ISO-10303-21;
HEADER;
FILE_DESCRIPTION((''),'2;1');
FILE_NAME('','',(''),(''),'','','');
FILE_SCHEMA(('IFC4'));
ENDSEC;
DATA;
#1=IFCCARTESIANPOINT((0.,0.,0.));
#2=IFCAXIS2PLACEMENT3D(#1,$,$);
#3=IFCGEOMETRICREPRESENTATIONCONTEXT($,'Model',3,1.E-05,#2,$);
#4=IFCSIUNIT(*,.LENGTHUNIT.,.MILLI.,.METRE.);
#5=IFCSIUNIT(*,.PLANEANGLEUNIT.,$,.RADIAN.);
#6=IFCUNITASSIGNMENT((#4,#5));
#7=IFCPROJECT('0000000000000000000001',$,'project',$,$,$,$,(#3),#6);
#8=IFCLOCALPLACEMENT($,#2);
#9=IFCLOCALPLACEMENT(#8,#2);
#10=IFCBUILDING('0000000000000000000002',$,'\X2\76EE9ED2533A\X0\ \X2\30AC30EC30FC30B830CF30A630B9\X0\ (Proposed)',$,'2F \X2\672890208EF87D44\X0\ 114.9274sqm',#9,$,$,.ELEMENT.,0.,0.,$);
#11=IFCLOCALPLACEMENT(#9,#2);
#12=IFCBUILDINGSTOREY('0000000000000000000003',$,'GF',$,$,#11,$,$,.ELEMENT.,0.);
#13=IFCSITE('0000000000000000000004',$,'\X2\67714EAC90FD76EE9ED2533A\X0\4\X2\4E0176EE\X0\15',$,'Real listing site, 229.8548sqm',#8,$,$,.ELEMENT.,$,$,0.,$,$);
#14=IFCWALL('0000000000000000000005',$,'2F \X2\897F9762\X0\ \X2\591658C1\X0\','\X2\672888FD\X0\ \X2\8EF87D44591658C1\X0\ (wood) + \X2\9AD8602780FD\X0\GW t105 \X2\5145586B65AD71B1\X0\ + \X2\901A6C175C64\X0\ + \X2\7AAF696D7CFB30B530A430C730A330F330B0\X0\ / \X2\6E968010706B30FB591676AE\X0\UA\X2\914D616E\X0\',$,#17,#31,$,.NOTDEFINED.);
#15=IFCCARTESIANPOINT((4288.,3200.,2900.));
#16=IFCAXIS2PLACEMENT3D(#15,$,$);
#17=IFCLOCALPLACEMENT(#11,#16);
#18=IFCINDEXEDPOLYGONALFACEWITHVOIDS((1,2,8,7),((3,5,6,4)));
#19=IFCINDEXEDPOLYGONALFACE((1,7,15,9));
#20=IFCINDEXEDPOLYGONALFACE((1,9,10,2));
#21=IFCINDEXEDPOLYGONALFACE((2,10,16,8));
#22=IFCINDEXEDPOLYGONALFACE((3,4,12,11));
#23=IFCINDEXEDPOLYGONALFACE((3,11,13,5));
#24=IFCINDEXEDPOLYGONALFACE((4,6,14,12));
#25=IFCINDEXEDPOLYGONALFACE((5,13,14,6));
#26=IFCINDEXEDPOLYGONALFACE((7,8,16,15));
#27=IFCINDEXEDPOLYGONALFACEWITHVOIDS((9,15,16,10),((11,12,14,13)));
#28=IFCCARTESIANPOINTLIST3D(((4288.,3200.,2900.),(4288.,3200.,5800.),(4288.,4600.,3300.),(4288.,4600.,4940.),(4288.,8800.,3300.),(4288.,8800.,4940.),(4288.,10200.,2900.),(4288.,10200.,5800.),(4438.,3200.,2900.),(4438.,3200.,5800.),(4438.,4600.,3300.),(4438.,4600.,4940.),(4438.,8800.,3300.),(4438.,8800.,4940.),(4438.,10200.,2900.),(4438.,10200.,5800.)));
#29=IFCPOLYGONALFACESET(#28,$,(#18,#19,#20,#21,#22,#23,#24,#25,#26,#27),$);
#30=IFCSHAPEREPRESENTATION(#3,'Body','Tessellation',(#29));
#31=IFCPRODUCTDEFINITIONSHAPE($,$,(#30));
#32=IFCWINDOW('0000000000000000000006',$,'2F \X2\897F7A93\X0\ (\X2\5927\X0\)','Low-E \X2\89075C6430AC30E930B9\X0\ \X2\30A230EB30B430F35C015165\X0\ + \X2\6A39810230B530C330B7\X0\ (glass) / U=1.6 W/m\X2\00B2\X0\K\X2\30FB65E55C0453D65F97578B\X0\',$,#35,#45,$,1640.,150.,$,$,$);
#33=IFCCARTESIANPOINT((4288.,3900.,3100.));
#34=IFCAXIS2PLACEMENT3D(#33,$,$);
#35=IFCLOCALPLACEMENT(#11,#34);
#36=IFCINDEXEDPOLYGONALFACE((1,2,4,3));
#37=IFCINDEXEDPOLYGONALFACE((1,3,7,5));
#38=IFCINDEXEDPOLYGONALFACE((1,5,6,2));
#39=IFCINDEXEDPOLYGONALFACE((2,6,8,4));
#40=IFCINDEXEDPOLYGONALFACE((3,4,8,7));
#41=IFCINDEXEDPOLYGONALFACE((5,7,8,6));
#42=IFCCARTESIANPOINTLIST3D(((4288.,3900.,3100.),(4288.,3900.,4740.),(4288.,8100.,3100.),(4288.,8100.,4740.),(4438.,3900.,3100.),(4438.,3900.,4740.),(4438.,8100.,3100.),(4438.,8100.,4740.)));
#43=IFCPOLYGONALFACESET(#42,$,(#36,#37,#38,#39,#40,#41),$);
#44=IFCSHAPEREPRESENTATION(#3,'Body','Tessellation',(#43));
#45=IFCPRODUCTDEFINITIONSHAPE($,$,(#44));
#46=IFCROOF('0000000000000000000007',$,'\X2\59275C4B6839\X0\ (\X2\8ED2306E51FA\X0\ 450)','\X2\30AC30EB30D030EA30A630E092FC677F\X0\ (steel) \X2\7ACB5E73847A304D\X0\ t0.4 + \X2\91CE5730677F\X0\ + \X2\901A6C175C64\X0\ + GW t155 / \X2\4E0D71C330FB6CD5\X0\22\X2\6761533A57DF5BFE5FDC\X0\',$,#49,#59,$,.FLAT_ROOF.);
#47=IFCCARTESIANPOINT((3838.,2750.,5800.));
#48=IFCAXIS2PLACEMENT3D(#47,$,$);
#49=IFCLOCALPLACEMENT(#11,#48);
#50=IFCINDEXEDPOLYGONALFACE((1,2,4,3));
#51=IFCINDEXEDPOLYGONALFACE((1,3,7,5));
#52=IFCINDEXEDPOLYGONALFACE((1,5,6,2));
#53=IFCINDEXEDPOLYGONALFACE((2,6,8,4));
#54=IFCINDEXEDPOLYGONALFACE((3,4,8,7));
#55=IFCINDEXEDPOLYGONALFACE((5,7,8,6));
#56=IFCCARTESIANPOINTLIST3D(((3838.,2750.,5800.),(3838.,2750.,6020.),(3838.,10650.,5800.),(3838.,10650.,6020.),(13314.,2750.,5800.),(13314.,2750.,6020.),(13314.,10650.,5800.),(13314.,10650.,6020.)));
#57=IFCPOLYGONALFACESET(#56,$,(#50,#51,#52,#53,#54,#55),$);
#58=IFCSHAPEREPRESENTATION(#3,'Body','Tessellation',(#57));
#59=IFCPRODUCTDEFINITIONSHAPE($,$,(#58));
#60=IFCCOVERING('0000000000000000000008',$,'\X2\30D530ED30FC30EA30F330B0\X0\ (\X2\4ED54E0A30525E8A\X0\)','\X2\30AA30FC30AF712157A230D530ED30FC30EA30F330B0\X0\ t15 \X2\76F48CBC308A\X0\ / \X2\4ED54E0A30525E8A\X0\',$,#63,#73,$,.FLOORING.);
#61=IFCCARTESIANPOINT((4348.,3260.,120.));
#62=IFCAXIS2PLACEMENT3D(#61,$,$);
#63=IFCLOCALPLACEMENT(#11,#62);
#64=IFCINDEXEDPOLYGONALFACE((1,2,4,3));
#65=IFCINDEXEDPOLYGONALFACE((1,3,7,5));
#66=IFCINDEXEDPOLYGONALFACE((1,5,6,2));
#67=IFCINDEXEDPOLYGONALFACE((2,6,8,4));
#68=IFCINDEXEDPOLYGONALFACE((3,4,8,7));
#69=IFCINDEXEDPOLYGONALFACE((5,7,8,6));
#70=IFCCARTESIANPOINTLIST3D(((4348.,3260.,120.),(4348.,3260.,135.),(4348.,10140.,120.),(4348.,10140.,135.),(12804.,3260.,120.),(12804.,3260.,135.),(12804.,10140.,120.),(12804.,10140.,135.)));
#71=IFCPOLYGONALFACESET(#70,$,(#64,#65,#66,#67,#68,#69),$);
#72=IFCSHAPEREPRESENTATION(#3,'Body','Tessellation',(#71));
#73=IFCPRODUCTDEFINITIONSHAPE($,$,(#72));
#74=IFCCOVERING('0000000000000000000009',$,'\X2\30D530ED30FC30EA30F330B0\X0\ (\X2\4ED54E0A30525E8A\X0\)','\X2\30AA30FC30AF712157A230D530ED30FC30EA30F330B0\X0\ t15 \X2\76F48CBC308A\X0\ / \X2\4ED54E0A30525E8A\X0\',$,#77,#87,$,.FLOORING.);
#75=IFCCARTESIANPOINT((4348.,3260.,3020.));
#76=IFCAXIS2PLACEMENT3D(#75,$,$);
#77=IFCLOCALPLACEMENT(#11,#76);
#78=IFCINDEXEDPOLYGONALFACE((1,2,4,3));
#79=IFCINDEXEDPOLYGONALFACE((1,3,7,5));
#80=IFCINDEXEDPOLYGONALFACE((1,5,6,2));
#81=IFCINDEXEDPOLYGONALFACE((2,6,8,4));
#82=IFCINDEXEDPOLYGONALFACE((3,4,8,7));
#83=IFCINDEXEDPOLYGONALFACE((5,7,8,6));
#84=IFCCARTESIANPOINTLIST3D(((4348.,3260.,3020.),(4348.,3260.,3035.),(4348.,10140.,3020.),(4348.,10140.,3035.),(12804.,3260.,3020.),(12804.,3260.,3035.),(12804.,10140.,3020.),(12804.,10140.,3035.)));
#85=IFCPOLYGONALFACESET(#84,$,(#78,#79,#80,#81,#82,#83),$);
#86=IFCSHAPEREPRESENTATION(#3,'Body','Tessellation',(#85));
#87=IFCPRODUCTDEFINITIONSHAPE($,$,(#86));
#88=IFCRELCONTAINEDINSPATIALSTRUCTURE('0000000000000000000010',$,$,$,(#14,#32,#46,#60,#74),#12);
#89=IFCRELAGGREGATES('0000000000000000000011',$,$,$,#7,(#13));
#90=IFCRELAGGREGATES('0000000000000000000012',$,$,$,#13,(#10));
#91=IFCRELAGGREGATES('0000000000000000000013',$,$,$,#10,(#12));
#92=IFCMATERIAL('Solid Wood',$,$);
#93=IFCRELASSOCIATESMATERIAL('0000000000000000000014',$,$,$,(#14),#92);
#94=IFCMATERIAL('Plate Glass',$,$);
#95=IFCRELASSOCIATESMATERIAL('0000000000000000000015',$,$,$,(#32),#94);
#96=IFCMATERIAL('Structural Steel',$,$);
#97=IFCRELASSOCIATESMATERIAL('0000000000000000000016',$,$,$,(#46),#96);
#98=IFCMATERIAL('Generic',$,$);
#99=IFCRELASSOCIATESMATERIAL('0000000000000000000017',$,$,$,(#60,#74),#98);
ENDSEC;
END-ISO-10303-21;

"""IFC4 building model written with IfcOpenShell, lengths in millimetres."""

from ifc_helpers import new_model, si_unit, frame, frame_2d, origin, place, context, project, spatial, rectangle, extrude, material, element, fill, save


model = new_model("IFC4")

# Units and contexts
model_context = context("Model", 3, precision=1e-05, world=origin())
ifc_project = project(units=[si_unit("LENGTHUNIT", "METRE", prefix="MILLI"), si_unit("PLANEANGLEUNIT", "RADIAN")], contexts=[model_context])

# Site, building, storey
site_placement = place(None, origin())
site = spatial("IfcSite", under=ifc_project, at=site_placement, Name="東京都目黒区4丁目15", ObjectType="Real listing site, 229.8548sqm", CompositionType="ELEMENT", RefElevation=0.0)
building_placement = place(site_placement, origin())
building = spatial("IfcBuilding", under=site, at=building_placement, Name="目黒区 ガレージハウス (Proposed)", ObjectType="2F 木造軸組 114.9274sqm", CompositionType="ELEMENT", ElevationOfRefHeight=0.0, ElevationOfTerrain=0.0)
storey_placement = place(building_placement, origin())
storey = spatial("IfcBuildingStorey", under=building, at=storey_placement, Name="GF", CompositionType="ELEMENT", Elevation=0.0)

# Shared definitions
ifc_material_1 = material(Name="Solid Wood")

# Shared definitions
ifc_material_2 = material(Name="Plate Glass")

# Wall, opening, window
wall_1_placement = place(storey_placement, frame((4288.0, 3200.0, 2900.0)))
wall_1 = element("IfcWall", 1, at=wall_1_placement, inside=storey, material=ifc_material_1, Name="2F 西面 外壁", Description="木製 軸組外壁 (wood) + 高性能GW t105 充填断熱 + 通気層 + 窯業系サイディング / 準耐火・外皮UA配慮", PredefinedType="NOTDEFINED", context=model_context, shape_type="SweptSolid", body=[
    extrude(rectangle(XDim=150.0, YDim=7000.0, at=frame_2d((75.0, 3500.0))), frame((4288.0, 3200.0, 2900.0)), (0.0, 0.0, 1.0), 2900.0),
])
opening_1_placement = place(storey_placement, frame((4288.0, 3900.0, 3100.0)))
opening_1 = element("IfcOpeningElement", 2, at=opening_1_placement, cuts=wall_1, PredefinedType="NOTDEFINED", context=model_context, shape_type="SweptSolid", body=[
    extrude(rectangle(XDim=150.0, YDim=4200.0, at=frame_2d((75.0, 2100.0))), frame((4288.0, 3900.0, 3100.0)), (0.0, 0.0, 1.0), 1640.0),
])
window_1_placement = place(storey_placement, frame((4288.0, 3900.0, 3100.0)))
window_1 = element("IfcWindow", 3, at=window_1_placement, inside=storey, material=ifc_material_2, Name="2F 西窓 (大)", Description="Low-E 複層ガラス アルゴン封入 + 樹脂サッシ (glass) / U=1.6 W/m²K・日射取得型", OverallHeight=1640.0, OverallWidth=150.0, context=model_context, shape_type="SweptSolid", body=[
    extrude(rectangle(XDim=150.0, YDim=4200.0, at=frame_2d((75.0, 2100.0))), frame((4288.0, 3900.0, 3100.0)), (0.0, 0.0, 1.0), 1640.0),
])
fill(opening_1, window_1)

# Roof
ifc_material_3 = material(Name="Structural Steel")
roof_placement = place(storey_placement, frame((3838.0, 2750.0, 5800.0)))
element("IfcRoof", 4, at=roof_placement, inside=storey, material=ifc_material_3, Name="大屋根 (軒の出 450)", Description="ガルバリウム鋼板 (steel) 立平葺き t0.4 + 野地板 + 通気層 + GW t155 / 不燃・法22条区域対応", PredefinedType="FLAT_ROOF", context=model_context, shape_type="SweptSolid", body=[
    extrude(rectangle(XDim=9476.0, YDim=7900.0, at=frame_2d((4738.0, 3950.0))), frame((3838.0, 2750.0, 5800.0)), (0.0, 0.0, 1.0), 220.0),
])

# Coverings
ifc_material_4 = material(Name="Generic")
covering_1_placement = place(storey_placement, frame((4348.0, 3260.0, 120.0)))
element("IfcCovering", 5, at=covering_1_placement, inside=storey, material=ifc_material_4, Name="フローリング (仕上げ床)", Description="オーク無垢フローリング t15 直貼り / 仕上げ床", PredefinedType="FLOORING", context=model_context, shape_type="SweptSolid", body=[
    extrude(rectangle(XDim=8456.0, YDim=6880.0, at=frame_2d((4228.0, 3440.0))), frame((4348.0, 3260.0, 120.0)), (0.0, 0.0, 1.0), 15.0),
])
covering_2_placement = place(storey_placement, frame((4348.0, 3260.0, 3020.0)))
element("IfcCovering", 6, at=covering_2_placement, inside=storey, material=ifc_material_4, Name="フローリング (仕上げ床)", Description="オーク無垢フローリング t15 直貼り / 仕上げ床", PredefinedType="FLOORING", context=model_context, shape_type="SweptSolid", body=[
    extrude(rectangle(XDim=8456.0, YDim=6880.0, at=frame_2d((4228.0, 3440.0))), frame((4348.0, 3260.0, 3020.0)), (0.0, 0.0, 1.0), 15.0),
])

save(model, "model.ifc")
